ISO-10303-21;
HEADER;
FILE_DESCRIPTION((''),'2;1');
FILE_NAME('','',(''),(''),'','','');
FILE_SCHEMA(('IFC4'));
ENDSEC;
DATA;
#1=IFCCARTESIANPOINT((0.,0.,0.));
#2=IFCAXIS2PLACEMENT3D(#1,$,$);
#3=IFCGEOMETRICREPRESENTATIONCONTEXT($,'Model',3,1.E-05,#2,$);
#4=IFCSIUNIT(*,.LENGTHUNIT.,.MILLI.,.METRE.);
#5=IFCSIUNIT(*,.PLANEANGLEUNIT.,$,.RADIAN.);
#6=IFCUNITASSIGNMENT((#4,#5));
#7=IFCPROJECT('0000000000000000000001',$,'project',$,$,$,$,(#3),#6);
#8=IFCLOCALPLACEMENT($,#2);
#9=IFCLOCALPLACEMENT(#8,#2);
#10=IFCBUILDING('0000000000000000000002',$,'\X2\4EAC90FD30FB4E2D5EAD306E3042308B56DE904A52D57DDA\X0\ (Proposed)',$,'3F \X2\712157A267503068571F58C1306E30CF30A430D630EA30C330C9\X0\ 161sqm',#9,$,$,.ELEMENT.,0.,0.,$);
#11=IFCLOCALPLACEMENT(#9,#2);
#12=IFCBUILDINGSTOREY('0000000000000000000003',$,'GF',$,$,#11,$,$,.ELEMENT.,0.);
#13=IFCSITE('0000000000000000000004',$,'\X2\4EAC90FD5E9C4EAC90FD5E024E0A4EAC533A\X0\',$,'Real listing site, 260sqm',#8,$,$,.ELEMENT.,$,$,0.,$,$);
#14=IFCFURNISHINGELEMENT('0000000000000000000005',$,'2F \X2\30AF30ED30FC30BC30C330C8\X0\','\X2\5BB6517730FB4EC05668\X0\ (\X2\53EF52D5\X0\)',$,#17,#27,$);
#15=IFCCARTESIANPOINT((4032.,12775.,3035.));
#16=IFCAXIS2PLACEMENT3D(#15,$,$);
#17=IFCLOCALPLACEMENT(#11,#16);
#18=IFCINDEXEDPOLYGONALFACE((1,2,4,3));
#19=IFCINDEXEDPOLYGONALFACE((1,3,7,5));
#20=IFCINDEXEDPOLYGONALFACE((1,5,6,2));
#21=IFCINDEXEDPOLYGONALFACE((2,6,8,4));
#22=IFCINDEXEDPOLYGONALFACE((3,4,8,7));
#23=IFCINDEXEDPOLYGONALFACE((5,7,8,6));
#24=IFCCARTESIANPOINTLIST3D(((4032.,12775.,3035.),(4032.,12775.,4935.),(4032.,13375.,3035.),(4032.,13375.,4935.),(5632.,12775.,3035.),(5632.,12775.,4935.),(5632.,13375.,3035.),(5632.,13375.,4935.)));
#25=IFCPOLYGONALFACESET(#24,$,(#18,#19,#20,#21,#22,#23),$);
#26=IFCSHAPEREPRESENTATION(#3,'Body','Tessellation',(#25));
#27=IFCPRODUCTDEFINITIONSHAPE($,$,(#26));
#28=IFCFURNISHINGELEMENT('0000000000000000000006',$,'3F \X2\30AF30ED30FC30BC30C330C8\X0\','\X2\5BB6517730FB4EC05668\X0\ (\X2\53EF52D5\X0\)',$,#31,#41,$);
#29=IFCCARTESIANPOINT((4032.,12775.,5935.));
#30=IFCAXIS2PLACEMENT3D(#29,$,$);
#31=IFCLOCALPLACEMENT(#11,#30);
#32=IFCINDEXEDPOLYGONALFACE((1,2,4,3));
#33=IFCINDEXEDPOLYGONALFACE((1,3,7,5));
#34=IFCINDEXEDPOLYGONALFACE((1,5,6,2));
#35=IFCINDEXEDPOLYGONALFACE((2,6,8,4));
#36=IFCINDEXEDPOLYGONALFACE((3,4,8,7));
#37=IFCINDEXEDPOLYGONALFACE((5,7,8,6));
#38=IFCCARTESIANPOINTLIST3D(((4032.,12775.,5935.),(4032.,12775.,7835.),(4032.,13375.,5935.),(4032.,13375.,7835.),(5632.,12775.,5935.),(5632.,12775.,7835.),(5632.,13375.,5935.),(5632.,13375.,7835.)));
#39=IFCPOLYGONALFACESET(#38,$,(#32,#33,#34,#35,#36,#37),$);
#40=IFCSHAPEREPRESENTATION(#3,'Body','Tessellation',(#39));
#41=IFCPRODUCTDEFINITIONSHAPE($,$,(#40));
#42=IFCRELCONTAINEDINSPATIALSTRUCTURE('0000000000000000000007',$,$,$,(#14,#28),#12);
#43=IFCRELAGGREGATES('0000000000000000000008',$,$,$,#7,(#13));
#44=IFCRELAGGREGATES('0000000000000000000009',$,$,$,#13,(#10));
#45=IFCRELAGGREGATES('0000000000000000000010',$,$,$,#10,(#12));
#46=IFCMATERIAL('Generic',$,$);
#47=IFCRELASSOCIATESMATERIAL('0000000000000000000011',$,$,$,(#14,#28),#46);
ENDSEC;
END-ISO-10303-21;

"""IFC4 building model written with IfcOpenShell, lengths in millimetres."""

from ifc_helpers import new_model, si_unit, frame, frame_2d, origin, place, context, project, spatial, rectangle, extrude, material, element, save


model = new_model("IFC4")

# Units and contexts
model_context = context("Model", 3, precision=1e-05, world=origin())
ifc_project = project(units=[si_unit("LENGTHUNIT", "METRE", prefix="MILLI"), si_unit("PLANEANGLEUNIT", "RADIAN")], contexts=[model_context])

# Site, building, storey
site_placement = place(None, origin())
site = spatial("IfcSite", under=ifc_project, at=site_placement, Name="京都府京都市上京区", ObjectType="Real listing site, 260sqm", CompositionType="ELEMENT", RefElevation=0.0)
building_placement = place(site_placement, origin())
building = spatial("IfcBuilding", under=site, at=building_placement, Name="京都・中庭のある回遊動線 (Proposed)", ObjectType="3F 無垢材と土壁のハイブリッド 161sqm", CompositionType="ELEMENT", ElevationOfRefHeight=0.0, ElevationOfTerrain=0.0)
storey_placement = place(building_placement, origin())
storey = spatial("IfcBuildingStorey", under=building, at=storey_placement, Name="GF", CompositionType="ELEMENT", Elevation=0.0)

# Shared definitions
ifc_material_1 = material(Name="Generic")

# Furnishing elements
furnishing_1_placement = place(storey_placement, frame((4032.0, 12775.0, 3035.0)))
element("IfcFurnishingElement", 1, at=furnishing_1_placement, inside=storey, material=ifc_material_1, Name="2F クローゼット", Description="家具・什器 (可動)", context=model_context, shape_type="SweptSolid", body=[
    extrude(rectangle(XDim=1600.0, YDim=600.0, at=frame_2d((800.0, 300.0))), frame((4032.0, 12775.0, 3035.0)), (0.0, 0.0, 1.0), 1900.0),
])
furnishing_2_placement = place(storey_placement, frame((4032.0, 12775.0, 5935.0)))
element("IfcFurnishingElement", 2, at=furnishing_2_placement, inside=storey, material=ifc_material_1, Name="3F クローゼット", Description="家具・什器 (可動)", context=model_context, shape_type="SweptSolid", body=[
    extrude(rectangle(XDim=1600.0, YDim=600.0, at=frame_2d((800.0, 300.0))), frame((4032.0, 12775.0, 5935.0)), (0.0, 0.0, 1.0), 1900.0),
])

save(model, "model.ifc")
